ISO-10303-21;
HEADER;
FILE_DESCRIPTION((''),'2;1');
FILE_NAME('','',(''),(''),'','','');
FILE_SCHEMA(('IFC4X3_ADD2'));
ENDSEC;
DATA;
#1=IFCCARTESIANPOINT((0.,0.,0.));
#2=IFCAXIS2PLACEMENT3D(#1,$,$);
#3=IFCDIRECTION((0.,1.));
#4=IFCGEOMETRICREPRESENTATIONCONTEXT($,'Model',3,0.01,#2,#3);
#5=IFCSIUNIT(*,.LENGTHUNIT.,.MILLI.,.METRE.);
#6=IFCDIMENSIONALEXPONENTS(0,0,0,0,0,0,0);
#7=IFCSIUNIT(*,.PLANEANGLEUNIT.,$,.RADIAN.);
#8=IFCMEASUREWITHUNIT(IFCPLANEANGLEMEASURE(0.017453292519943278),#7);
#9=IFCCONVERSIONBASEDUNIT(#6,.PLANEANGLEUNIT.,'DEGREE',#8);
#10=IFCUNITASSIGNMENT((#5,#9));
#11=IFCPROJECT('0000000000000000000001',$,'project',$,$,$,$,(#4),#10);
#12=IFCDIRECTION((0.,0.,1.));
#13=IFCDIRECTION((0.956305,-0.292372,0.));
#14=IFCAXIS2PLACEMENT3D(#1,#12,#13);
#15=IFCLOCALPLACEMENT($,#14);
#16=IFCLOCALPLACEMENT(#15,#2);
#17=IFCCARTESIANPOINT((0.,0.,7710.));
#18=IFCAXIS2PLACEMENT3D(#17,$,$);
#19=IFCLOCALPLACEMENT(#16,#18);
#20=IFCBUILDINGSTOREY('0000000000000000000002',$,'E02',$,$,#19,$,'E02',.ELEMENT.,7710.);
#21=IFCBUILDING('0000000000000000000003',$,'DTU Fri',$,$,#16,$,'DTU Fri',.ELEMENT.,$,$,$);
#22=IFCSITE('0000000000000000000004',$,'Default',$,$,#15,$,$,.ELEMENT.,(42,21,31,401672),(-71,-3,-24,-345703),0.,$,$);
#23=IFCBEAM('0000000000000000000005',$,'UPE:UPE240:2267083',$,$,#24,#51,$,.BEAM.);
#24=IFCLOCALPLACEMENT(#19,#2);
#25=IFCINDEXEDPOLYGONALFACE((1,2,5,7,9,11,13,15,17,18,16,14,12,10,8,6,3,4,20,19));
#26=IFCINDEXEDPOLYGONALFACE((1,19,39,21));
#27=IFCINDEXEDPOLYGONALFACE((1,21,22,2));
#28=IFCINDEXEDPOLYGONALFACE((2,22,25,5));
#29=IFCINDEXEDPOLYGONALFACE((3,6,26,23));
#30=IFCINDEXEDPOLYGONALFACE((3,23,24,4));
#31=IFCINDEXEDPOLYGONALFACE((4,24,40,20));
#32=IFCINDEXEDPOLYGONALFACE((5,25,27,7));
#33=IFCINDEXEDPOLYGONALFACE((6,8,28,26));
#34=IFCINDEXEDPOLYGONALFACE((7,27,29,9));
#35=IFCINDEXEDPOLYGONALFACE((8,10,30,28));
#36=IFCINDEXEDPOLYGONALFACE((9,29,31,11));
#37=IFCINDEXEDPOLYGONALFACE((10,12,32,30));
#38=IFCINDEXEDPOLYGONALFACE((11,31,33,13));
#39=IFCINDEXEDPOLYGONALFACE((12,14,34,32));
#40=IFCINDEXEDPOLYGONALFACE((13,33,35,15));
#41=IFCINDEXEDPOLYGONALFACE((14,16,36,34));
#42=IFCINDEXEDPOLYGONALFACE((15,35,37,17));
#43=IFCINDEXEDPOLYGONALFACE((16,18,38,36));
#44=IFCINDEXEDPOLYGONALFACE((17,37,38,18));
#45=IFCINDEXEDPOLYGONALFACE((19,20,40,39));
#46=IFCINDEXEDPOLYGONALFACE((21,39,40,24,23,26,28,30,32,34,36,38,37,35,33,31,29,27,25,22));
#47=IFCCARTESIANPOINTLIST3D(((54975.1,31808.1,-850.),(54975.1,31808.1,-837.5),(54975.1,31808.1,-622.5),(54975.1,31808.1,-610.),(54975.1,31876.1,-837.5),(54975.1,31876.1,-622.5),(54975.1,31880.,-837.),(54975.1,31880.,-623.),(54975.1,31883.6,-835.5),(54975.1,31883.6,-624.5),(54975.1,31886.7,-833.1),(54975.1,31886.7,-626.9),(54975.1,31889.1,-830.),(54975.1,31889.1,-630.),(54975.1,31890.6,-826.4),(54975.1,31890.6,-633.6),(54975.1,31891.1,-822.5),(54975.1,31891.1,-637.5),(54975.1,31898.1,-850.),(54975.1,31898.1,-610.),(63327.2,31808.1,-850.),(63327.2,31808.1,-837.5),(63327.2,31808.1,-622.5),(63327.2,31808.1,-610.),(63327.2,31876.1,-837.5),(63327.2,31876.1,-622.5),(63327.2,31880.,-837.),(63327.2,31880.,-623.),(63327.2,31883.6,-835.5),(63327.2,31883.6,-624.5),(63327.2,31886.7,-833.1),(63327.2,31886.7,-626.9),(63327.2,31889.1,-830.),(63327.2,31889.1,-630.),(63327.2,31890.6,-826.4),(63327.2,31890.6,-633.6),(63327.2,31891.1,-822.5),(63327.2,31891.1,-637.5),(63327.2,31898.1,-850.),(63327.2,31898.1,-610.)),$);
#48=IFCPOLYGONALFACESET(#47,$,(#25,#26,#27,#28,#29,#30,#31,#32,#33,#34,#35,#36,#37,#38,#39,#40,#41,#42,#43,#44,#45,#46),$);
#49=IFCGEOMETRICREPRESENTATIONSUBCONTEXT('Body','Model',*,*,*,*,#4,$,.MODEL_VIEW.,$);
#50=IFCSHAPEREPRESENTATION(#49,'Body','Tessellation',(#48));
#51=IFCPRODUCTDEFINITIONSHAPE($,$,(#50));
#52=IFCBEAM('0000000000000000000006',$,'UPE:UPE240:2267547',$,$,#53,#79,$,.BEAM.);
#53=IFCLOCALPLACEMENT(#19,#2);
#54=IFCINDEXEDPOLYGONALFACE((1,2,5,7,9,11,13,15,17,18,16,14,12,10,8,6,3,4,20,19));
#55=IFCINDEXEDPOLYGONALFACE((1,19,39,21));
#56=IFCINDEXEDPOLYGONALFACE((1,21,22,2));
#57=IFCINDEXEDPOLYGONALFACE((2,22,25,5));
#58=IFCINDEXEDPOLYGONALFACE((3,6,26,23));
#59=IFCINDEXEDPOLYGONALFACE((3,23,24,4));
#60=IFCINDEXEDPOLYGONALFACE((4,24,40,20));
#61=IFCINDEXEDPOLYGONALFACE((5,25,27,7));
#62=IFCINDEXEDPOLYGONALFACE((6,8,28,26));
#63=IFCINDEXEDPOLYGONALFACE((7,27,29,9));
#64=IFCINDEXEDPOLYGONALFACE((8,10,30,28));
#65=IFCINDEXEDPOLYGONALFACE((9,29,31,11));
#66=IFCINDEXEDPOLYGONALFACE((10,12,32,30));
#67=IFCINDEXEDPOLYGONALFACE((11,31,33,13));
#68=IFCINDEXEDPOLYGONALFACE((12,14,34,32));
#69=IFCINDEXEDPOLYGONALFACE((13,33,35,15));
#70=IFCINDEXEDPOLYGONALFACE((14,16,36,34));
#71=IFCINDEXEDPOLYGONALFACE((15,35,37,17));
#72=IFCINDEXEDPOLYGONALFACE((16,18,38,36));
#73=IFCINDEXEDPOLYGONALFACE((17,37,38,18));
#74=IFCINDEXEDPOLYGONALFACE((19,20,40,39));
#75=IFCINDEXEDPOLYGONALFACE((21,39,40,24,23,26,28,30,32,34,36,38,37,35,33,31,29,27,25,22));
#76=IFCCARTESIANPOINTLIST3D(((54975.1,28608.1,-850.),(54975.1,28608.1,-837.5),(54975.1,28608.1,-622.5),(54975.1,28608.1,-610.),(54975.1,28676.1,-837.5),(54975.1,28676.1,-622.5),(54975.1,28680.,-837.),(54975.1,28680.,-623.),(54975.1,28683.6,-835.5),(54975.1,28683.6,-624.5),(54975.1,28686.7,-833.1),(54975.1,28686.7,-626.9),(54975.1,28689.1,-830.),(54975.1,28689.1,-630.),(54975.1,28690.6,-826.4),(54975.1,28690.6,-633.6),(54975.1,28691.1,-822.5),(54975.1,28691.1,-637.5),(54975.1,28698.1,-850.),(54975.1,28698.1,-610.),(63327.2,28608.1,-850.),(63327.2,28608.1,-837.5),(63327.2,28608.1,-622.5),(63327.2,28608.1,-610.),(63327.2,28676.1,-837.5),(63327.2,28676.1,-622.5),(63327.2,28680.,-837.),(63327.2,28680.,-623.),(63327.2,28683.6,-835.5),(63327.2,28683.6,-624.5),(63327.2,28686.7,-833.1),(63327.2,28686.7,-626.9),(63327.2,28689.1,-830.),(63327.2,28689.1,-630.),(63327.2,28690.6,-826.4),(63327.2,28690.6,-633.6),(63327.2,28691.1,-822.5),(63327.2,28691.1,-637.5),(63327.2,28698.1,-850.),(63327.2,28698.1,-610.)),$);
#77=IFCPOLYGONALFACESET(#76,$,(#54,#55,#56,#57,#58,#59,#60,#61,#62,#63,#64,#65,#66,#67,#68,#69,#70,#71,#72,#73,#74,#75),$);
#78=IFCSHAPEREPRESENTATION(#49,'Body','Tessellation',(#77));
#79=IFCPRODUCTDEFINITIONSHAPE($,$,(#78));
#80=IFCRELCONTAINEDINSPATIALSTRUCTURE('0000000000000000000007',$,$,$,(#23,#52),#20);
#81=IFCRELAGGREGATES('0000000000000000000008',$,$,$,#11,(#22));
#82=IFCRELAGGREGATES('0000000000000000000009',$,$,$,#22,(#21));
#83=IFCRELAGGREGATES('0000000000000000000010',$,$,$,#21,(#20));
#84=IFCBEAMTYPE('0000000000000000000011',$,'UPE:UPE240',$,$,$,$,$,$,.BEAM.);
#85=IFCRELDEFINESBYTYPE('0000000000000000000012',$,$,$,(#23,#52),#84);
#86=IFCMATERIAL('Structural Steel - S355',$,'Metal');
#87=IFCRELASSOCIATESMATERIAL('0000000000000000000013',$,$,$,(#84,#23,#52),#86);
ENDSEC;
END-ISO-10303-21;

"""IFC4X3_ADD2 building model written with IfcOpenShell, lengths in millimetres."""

from ifc_helpers import new_model, entity, si_unit, converted_unit, direction, frame, frame_2d, origin, place, context, subcontext, project, spatial, polyline, circle_curve, parameter, trimmed, segment, composite_curve, outline, extrude, source, transform, mapped, material, material_profile, profile_set, profile_usage, type_object, type_shapes, element, save


model = new_model("IFC4X3_ADD2")

# Units and contexts
model_context = context("Model", 3, precision=0.01, world=origin(), true_north=direction((0.0, 1.0)))
body_context = subcontext(model_context, "Body", "Model", "MODEL_VIEW")
ifc_project = project(units=[si_unit("LENGTHUNIT", "METRE", prefix="MILLI"), converted_unit("PLANEANGLEUNIT", "DEGREE", entity("IfcPlaneAngleMeasure", 0.017453292519943278), si_unit("PLANEANGLEUNIT", "RADIAN"), dimensions=[0, 0, 0, 0, 0, 0, 0])], contexts=[model_context])

# Site, building, storey
site_placement = place(None, frame((0.0, 0.0, 0.0), z_axis=(0.0, 0.0, 1.0), x_axis=(0.956305, -0.292372, 0.0)))
site = spatial("IfcSite", under=ifc_project, at=site_placement, Name="Default", CompositionType="ELEMENT", RefLatitude=(42, 21, 31, 401672), RefLongitude=(-71, -3, -24, -345703), RefElevation=0.0)
building_placement = place(site_placement, origin())
building = spatial("IfcBuilding", under=site, at=building_placement, Name="DTU Fri", LongName="DTU Fri", CompositionType="ELEMENT")
storey_placement = place(building_placement, frame((0.0, 0.0, 7710.0)))
storey = spatial("IfcBuildingStorey", under=building, at=storey_placement, Name="E02", LongName="E02", CompositionType="ELEMENT", Elevation=7710.0)

# Beams
ifc_material_1 = material(Name="Structural Steel - S355", Category="Metal")
ifc_material_profile_1 = material_profile(ifc_material_1, outline(composite_curve([segment(polyline([(-120.0, -48.2), (-107.5, -48.2)]), True, "CONTINUOUS"), segment(polyline([(-107.5, -48.2), (-107.5, 19.8)]), True, "CONTINUOUS"), segment(trimmed(circle_curve(frame_2d((-92.5, 19.8), x_axis=(-1.0, 0.0)), 15.0), [parameter(270.0)], [parameter(0.0)], True, "PARAMETER"), False, "CONTINUOUS"), segment(polyline([(-92.5, 34.8), (92.5, 34.8)]), True, "CONTINUOUS"), segment(trimmed(circle_curve(frame_2d((92.5, 19.8), x_axis=(0.0, 1.0)), 15.0), [parameter(270.0)], [parameter(0.0)], True, "PARAMETER"), False, "CONTINUOUS"), segment(polyline([(107.5, 19.8), (107.5, -48.2)]), True, "CONTINUOUS"), segment(polyline([(107.5, -48.2), (120.0, -48.2)]), True, "CONTINUOUS"), segment(polyline([(120.0, -48.2), (120.0, 41.8)]), True, "CONTINUOUS"), segment(polyline([(120.0, 41.8), (-120.0, 41.8)]), True, "CONTINUOUS"), segment(polyline([(-120.0, 41.8), (-120.0, -48.2)]), True, "CONTINUOUS")], self_intersect=False)), Name="UPE240")
ifc_profile_set_1 = profile_set([ifc_material_profile_1], Name="UPE240")
ifc_profile_usage_1 = profile_usage(ifc_profile_set_1, cardinal=8)
beam_type_1 = type_object("IfcBeamType", Name="UPE:UPE240", PredefinedType="BEAM", material=ifc_profile_set_1)
shared_shape_1 = source(origin(), body_context, "Body", "SweptSolid", [
    extrude(outline(composite_curve([segment(polyline([(-120.0, -48.2), (-107.5, -48.2)]), True, "CONTINUOUS"), segment(polyline([(-107.5, -48.2), (-107.5, 19.8)]), True, "CONTINUOUS"), segment(trimmed(circle_curve(frame_2d((-92.5, 19.8), x_axis=(-1.0, 0.0)), 15.0), [parameter(270.0)], [parameter(0.0)], True, "PARAMETER"), False, "CONTINUOUS"), segment(polyline([(-92.5, 34.8), (92.5, 34.8)]), True, "CONTINUOUS"), segment(trimmed(circle_curve(frame_2d((92.5, 19.8), x_axis=(0.0, 1.0)), 15.0), [parameter(270.0)], [parameter(0.0)], True, "PARAMETER"), False, "CONTINUOUS"), segment(polyline([(107.5, 19.8), (107.5, -48.2)]), True, "CONTINUOUS"), segment(polyline([(107.5, -48.2), (120.0, -48.2)]), True, "CONTINUOUS"), segment(polyline([(120.0, -48.2), (120.0, 41.8)]), True, "CONTINUOUS"), segment(polyline([(120.0, 41.8), (-120.0, 41.8)]), True, "CONTINUOUS"), segment(polyline([(-120.0, 41.8), (-120.0, -48.2)]), True, "CONTINUOUS")], self_intersect=False)), frame((-4182.4, -13.9, 0.0), z_axis=(1.0, 0.0, 0.0), x_axis=(0.0, 0.0, -1.0)), (0.0, 0.0, 1.0), 8352.1),
])
type_shapes(beam_type_1, [shared_shape_1])
for number, where, name in (
    (1, (59157.5, 31870.2, -730.0), "UPE:UPE240:2267083"),
    (2, (59157.5, 28670.2, -730.0), "UPE:UPE240:2267547"),
):
    element("IfcBeam", number, at=place(storey_placement, frame(where)), inside=storey, type_object=beam_type_1, material=ifc_profile_usage_1, Name=name, PredefinedType="BEAM", context=body_context, shape_type="MappedRepresentation", body=[
        mapped(shared_shape_1, transform((0.0, 0.0, 0.0), scale=1.0)),
    ])

save(model, "model.ifc")
